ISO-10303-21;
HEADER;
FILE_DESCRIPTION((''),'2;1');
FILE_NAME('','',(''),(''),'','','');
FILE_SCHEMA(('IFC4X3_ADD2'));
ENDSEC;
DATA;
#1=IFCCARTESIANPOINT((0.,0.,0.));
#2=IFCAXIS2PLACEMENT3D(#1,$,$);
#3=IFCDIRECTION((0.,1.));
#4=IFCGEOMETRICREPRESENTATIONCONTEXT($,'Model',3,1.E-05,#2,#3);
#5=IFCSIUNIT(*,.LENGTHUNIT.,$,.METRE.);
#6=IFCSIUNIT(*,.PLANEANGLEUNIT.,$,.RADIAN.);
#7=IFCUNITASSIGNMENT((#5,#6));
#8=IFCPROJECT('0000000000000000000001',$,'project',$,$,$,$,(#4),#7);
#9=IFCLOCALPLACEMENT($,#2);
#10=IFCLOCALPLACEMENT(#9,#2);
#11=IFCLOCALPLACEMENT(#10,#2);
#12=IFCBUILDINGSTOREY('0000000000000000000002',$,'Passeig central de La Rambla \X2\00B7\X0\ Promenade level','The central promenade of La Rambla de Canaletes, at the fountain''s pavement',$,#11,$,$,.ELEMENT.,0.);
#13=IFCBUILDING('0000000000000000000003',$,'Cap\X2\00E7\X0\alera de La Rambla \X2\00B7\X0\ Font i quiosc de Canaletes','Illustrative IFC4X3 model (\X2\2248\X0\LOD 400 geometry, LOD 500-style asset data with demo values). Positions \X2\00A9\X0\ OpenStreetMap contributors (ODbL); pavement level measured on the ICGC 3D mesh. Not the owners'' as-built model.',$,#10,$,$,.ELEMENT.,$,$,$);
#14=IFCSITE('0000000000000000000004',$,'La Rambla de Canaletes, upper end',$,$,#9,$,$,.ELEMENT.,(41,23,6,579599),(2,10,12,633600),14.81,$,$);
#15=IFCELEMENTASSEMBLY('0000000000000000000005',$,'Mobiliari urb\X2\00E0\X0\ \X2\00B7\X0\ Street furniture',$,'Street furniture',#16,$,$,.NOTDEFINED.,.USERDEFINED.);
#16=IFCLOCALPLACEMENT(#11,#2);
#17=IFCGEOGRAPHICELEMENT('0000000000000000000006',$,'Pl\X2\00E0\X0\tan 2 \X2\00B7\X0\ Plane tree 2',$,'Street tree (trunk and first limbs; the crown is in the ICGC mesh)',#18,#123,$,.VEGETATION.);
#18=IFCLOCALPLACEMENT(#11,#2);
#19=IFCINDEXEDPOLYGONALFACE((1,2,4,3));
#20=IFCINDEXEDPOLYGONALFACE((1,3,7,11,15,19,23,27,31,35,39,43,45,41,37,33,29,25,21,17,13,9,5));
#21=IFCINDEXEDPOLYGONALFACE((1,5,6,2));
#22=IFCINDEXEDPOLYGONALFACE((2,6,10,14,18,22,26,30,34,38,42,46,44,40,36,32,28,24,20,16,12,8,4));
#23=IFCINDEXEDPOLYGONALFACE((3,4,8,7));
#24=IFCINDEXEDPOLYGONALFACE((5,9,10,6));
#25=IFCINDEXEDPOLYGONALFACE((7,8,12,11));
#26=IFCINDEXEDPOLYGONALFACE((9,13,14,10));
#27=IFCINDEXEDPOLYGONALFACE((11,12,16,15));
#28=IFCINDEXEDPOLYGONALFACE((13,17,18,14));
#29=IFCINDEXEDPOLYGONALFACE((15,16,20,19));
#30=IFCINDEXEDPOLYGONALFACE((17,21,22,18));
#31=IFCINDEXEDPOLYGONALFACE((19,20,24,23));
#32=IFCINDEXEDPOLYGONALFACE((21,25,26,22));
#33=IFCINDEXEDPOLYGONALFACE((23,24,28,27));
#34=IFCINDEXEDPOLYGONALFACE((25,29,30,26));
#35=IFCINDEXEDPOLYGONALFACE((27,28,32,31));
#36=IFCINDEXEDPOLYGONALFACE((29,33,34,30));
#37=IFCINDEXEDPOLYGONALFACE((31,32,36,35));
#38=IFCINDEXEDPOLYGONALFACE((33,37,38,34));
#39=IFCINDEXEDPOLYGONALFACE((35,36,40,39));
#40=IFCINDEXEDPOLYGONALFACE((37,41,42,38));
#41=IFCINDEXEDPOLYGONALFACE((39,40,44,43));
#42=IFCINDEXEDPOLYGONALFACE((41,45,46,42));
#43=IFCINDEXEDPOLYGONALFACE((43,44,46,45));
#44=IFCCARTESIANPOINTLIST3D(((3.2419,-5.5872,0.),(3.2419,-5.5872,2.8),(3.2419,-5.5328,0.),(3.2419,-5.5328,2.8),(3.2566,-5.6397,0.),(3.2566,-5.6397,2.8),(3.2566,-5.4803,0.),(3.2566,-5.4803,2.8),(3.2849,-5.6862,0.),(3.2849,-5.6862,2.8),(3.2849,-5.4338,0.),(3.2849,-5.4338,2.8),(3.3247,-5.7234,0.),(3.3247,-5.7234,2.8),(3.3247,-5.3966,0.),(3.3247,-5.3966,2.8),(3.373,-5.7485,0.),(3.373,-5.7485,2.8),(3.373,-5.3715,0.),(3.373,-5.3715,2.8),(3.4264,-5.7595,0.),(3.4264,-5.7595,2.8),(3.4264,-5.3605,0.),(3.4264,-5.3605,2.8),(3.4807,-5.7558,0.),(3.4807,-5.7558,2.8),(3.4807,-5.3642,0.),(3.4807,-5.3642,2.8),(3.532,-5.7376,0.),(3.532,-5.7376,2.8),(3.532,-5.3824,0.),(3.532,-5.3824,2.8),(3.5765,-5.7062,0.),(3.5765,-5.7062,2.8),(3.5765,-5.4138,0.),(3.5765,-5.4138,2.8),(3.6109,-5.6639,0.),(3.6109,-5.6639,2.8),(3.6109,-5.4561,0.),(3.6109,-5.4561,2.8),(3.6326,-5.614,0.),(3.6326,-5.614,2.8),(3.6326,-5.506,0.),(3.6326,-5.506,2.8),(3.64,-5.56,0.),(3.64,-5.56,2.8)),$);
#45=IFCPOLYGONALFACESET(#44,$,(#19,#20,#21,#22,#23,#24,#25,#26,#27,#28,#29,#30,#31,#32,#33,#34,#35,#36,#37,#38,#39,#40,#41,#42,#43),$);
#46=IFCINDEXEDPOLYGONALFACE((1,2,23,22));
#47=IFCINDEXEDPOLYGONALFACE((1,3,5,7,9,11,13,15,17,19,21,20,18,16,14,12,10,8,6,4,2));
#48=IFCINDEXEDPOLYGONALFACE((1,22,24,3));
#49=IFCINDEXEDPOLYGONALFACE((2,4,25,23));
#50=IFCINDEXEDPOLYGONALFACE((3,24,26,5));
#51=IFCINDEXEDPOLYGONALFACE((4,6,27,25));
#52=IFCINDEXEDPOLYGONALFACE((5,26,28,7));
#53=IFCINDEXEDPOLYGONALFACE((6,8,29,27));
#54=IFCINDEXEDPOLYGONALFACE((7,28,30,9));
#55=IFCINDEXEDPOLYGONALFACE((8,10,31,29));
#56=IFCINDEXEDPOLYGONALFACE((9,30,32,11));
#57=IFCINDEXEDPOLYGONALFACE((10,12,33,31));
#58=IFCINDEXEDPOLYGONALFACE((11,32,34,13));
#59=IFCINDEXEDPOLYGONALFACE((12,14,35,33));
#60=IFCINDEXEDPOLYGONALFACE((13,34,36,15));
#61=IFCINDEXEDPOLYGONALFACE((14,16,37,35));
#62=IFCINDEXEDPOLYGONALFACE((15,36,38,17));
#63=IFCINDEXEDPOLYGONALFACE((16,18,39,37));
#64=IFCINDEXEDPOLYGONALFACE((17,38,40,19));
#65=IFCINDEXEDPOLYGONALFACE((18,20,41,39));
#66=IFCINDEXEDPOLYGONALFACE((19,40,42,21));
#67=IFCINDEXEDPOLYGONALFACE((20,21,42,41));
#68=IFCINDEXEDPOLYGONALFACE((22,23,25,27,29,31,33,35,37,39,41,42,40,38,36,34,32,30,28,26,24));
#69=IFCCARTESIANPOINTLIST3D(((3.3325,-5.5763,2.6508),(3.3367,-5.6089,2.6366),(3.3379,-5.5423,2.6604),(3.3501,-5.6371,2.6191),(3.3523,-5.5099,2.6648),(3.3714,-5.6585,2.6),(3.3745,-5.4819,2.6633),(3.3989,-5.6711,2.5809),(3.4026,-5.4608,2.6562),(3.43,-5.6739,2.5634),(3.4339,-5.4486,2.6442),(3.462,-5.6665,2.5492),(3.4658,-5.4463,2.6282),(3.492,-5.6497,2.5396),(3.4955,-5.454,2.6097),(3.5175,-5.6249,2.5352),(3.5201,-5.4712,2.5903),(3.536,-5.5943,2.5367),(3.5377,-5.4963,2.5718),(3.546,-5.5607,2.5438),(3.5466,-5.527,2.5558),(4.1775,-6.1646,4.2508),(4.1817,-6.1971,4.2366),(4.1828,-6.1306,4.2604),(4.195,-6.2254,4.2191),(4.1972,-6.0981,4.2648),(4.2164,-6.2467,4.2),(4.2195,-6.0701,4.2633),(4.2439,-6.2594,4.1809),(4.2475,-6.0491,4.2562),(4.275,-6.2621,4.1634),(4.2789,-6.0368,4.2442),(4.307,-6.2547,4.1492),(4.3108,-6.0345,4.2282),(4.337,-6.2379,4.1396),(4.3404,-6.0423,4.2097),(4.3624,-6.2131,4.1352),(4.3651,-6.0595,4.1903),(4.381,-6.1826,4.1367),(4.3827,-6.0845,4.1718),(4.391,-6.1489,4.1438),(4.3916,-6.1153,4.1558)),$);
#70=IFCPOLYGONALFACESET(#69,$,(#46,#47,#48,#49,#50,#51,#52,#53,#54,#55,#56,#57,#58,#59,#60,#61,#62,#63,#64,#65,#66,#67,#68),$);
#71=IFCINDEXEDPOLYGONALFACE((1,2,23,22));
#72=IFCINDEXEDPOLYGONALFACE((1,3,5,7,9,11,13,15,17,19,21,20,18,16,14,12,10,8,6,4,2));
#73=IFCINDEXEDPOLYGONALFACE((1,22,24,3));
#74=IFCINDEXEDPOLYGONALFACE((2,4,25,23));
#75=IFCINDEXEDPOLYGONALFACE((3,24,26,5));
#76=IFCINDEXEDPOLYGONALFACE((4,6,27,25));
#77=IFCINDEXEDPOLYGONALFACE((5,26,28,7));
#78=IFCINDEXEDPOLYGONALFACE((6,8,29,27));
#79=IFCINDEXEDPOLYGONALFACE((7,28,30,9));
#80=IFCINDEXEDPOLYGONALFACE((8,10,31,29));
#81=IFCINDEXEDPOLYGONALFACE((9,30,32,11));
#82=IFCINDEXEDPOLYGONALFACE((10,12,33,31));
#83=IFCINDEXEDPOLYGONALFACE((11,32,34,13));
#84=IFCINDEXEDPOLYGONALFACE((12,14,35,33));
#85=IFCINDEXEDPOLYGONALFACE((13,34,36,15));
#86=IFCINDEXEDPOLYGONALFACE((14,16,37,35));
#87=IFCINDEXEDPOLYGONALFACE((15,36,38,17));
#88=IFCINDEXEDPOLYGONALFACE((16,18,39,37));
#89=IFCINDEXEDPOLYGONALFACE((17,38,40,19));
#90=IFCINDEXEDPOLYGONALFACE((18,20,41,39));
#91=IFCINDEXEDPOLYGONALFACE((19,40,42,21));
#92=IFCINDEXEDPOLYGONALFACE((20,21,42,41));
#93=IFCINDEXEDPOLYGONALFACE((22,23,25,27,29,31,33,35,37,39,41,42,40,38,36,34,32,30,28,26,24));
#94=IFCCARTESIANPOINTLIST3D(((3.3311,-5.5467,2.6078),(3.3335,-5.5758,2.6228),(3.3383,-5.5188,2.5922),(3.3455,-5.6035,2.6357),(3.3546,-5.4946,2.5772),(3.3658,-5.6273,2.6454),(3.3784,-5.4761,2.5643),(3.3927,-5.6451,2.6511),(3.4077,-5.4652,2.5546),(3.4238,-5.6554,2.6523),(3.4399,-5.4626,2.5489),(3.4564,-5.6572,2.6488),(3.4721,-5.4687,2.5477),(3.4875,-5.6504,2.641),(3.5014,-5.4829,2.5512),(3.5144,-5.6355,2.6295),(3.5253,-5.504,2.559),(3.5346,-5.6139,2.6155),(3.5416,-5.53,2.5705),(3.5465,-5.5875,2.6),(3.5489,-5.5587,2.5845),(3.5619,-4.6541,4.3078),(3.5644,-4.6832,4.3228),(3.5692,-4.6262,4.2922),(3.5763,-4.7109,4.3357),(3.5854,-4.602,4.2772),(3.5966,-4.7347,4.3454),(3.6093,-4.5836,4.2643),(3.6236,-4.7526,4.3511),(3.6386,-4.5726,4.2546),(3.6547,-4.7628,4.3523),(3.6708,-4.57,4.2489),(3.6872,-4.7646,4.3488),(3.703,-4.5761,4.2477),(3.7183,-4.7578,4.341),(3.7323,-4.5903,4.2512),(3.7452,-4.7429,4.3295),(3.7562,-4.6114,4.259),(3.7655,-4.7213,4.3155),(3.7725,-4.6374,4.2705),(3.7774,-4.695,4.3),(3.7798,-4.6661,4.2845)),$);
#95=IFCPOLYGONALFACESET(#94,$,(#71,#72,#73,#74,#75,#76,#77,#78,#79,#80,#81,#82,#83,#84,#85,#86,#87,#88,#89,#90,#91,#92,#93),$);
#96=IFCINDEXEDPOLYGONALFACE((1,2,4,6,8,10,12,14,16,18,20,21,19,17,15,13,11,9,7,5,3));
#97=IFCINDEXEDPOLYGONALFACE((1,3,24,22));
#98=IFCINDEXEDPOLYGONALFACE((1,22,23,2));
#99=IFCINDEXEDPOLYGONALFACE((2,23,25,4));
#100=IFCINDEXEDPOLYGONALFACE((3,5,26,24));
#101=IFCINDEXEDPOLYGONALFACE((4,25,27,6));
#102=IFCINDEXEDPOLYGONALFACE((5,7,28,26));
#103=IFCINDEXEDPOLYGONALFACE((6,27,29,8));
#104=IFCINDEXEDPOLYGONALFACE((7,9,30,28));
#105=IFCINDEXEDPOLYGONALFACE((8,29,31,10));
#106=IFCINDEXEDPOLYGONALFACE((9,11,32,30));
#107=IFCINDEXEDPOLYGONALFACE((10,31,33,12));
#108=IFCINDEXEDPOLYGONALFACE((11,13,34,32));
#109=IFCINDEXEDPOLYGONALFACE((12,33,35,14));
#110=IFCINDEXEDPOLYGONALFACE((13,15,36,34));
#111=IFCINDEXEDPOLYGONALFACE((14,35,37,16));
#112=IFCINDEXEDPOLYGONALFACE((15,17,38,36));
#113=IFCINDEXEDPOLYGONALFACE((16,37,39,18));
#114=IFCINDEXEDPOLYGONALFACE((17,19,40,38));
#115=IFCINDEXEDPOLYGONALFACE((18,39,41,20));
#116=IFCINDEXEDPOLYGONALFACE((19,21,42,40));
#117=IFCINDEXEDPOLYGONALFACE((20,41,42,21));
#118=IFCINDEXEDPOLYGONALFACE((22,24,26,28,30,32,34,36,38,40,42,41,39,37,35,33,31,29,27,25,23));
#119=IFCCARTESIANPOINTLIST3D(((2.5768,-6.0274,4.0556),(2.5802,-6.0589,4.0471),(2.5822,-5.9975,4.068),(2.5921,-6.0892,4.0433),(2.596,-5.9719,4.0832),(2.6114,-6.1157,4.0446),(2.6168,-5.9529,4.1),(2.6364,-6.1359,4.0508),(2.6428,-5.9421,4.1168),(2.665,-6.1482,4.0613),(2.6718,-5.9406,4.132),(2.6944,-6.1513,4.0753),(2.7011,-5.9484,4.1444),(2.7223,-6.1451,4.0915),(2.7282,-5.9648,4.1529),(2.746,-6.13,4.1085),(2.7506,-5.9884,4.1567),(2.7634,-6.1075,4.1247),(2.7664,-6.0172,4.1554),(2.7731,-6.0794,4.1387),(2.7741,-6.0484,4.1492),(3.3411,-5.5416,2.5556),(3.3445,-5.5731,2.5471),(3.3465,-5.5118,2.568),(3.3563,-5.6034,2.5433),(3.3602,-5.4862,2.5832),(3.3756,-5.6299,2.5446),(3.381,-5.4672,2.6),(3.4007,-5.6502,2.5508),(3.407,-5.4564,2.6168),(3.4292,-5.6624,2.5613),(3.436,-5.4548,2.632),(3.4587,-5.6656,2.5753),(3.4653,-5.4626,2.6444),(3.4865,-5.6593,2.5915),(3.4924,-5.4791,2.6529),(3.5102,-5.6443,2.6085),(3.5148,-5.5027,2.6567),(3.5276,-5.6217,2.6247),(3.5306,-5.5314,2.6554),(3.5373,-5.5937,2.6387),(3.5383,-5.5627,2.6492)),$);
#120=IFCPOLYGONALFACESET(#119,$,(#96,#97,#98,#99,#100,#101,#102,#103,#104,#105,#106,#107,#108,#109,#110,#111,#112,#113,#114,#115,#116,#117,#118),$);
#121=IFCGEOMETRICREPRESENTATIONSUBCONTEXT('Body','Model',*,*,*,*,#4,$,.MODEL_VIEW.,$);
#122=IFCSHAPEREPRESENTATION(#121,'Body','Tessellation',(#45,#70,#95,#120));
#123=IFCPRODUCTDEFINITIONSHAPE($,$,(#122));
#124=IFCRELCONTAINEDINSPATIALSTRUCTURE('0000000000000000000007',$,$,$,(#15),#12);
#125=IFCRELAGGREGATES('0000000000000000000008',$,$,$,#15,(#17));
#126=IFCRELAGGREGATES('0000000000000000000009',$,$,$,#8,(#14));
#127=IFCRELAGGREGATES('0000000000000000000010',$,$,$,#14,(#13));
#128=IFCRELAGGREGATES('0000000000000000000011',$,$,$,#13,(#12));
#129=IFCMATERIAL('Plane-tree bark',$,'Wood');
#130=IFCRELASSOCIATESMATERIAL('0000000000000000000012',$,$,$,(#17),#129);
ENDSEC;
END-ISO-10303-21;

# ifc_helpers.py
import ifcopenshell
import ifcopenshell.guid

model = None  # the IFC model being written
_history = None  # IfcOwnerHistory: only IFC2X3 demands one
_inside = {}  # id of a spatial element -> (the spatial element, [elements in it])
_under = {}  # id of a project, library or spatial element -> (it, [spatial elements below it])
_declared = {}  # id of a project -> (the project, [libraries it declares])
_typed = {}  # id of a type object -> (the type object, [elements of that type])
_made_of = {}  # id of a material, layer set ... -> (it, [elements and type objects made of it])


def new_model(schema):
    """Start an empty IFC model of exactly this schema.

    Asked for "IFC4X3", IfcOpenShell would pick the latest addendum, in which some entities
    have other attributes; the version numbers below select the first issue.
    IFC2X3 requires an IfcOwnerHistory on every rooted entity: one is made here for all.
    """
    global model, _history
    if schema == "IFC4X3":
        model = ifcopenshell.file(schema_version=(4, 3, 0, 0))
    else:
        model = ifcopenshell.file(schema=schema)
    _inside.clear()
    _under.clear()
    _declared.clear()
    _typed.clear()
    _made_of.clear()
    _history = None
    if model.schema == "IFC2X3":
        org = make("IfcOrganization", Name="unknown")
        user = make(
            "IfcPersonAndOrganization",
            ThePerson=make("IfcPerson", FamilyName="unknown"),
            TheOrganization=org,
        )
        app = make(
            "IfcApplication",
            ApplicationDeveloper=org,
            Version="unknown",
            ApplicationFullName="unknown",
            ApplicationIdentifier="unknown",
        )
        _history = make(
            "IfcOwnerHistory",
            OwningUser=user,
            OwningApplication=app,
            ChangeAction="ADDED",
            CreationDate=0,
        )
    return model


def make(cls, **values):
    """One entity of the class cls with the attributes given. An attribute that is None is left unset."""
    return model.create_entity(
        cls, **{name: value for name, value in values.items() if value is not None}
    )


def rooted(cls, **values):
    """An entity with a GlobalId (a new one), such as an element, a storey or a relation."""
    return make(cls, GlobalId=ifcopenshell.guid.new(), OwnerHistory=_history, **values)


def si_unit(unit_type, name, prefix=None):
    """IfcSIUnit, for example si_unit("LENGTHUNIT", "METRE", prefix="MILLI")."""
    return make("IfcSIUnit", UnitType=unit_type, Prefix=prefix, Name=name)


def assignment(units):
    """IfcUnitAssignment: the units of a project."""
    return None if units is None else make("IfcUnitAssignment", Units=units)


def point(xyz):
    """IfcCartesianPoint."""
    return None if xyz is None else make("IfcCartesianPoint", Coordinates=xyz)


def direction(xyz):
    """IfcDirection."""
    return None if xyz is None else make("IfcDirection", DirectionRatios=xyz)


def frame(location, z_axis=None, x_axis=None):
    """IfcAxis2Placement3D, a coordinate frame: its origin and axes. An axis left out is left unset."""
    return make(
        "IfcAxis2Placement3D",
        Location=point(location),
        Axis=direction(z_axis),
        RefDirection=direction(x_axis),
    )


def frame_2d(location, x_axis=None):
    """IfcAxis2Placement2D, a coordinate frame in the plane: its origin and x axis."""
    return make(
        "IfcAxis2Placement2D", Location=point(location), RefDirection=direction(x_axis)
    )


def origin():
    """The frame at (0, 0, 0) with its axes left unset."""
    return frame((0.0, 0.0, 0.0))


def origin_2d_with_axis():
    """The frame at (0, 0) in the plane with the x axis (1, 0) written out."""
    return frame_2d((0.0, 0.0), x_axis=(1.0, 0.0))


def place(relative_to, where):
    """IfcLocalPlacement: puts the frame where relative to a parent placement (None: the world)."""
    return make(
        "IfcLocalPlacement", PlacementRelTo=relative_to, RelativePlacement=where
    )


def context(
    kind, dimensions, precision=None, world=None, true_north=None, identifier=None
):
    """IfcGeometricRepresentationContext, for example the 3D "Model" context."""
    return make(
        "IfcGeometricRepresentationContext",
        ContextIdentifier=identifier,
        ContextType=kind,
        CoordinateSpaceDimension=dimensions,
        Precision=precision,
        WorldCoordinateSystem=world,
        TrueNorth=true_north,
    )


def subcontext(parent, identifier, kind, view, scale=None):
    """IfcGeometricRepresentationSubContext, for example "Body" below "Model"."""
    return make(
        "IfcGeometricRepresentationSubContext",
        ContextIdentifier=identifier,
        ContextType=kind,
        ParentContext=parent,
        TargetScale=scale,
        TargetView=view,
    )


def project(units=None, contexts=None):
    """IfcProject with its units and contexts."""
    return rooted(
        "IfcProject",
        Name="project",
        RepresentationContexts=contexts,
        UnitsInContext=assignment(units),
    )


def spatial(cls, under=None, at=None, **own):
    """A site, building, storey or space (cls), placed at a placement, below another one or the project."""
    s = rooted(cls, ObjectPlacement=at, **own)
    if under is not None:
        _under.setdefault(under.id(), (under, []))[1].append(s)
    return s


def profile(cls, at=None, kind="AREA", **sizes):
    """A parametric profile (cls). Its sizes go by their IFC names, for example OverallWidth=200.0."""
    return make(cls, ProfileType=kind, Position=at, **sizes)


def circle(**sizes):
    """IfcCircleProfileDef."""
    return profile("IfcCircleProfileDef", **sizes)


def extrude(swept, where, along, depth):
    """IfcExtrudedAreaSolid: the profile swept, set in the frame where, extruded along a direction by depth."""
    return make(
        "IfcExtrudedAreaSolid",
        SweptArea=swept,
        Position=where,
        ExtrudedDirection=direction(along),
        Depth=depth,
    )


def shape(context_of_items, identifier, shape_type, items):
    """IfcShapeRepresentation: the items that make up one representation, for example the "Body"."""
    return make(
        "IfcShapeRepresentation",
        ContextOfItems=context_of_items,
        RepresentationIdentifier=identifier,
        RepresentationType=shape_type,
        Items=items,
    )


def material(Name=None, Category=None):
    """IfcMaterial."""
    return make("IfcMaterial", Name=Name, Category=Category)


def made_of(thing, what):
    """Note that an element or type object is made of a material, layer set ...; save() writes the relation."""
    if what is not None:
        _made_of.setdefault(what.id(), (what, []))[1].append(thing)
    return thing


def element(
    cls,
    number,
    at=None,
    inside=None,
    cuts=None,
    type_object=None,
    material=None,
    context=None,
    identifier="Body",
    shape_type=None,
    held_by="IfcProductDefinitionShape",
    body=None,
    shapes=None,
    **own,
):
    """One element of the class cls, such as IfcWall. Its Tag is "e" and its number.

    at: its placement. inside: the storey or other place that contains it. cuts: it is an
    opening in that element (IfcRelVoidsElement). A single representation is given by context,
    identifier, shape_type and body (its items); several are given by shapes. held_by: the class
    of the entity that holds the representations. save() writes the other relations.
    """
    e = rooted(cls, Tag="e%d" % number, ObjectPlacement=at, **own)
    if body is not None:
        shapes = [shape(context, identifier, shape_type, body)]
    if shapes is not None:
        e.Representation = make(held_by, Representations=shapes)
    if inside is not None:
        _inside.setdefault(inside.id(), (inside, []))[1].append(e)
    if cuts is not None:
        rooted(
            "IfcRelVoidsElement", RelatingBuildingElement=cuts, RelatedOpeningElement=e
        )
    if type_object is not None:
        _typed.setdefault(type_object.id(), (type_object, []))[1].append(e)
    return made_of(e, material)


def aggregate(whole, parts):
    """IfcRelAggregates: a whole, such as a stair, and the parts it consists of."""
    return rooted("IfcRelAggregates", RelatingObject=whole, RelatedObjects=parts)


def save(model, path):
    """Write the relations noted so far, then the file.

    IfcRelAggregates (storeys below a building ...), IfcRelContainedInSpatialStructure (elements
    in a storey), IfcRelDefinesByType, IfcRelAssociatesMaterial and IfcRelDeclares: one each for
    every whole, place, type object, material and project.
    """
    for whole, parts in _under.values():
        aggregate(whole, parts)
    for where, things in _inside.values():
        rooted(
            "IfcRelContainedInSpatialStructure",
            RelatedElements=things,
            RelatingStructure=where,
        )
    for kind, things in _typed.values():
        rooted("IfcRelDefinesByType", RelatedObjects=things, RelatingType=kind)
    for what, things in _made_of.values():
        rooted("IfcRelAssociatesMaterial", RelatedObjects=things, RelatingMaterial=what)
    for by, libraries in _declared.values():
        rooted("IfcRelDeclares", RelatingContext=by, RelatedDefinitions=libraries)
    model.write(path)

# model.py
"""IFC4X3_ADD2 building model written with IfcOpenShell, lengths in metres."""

from ifc_helpers import new_model, si_unit, direction, frame, origin, origin_2d_with_axis, place, context, subcontext, project, spatial, circle, extrude, material, element, aggregate, save


model = new_model("IFC4X3_ADD2")

# Units and contexts
model_context = context("Model", 3, precision=1e-05, world=origin(), true_north=direction((0.0, 1.0)))
body_context = subcontext(model_context, "Body", "Model", "MODEL_VIEW")
ifc_project = project(units=[si_unit("LENGTHUNIT", "METRE"), si_unit("PLANEANGLEUNIT", "RADIAN")], contexts=[model_context])

# Site, building, storey
site_placement = place(None, origin())
site = spatial("IfcSite", under=ifc_project, at=site_placement, Name="La Rambla de Canaletes, upper end", CompositionType="ELEMENT", RefLatitude=(41, 23, 6, 579599), RefLongitude=(2, 10, 12, 633600), RefElevation=14.81)
building_placement = place(site_placement, origin())
building = spatial("IfcBuilding", under=site, at=building_placement, Name="Capçalera de La Rambla · Font i quiosc de Canaletes", Description="Illustrative IFC4X3 model (≈LOD 400 geometry, LOD 500-style asset data with demo values). Positions © OpenStreetMap contributors (ODbL); pavement level measured on the ICGC 3D mesh. Not the owners' as-built model.", CompositionType="ELEMENT")
storey_placement = place(building_placement, origin())
storey = spatial("IfcBuildingStorey", under=building, at=storey_placement, Name="Passeig central de La Rambla · Promenade level", Description="The central promenade of La Rambla de Canaletes, at the fountain's pavement", CompositionType="ELEMENT", Elevation=0.0)

# Element assembly
assembly_1_placement = place(building_placement, origin())
assembly_1 = element("IfcElementAssembly", 1, at=assembly_1_placement, inside=storey, Name="Mobiliari urbà · Street furniture", ObjectType="Street furniture", AssemblyPlace="NOTDEFINED", PredefinedType="USERDEFINED")

# Geographic element
ifc_material_1 = material(Name="Plane-tree bark", Category="Wood")
geographic_element_1_placement = place(building_placement, origin())
geographic_element_1 = element("IfcGeographicElement", 2, at=geographic_element_1_placement, material=ifc_material_1, Name="Plàtan 2 · Plane tree 2", ObjectType="Street tree (trunk and first limbs; the crown is in the ICGC mesh)", PredefinedType="VEGETATION", context=body_context, shape_type="SweptSolid", body=[
    extrude(circle(Radius=0.2, at=origin_2d_with_axis()), frame((3.44, -5.56, 0.0)), (0.0, 0.0, 1.0), 2.8),
    extrude(circle(Radius=0.12, at=origin_2d_with_axis()), frame((3.44, -5.56, 2.6), z_axis=(0.444101, -0.30918, 0.840941), x_axis=(-0.571364, -0.820697, 0.0)), (0.0, 0.0, 1.0), 1.9026),
    extrude(circle(Radius=0.11, at=origin_2d_with_axis()), frame((3.44, -5.56, 2.6), z_axis=(0.119374, 0.461544, 0.879049), x_axis=(0.968142, -0.250402, 0.0)), (0.0, 0.0, 1.0), 1.9339),
    extrude(circle(Radius=0.11, at=origin_2d_with_axis()), frame((3.44, -5.56, 2.6), z_axis=(-0.43617, -0.277231, 0.856095), x_axis=(-0.536419, 0.843952, 0.0)), (0.0, 0.0, 1.0), 1.7521),
])
aggregate(assembly_1, [geographic_element_1])

save(model, "model.ifc")
